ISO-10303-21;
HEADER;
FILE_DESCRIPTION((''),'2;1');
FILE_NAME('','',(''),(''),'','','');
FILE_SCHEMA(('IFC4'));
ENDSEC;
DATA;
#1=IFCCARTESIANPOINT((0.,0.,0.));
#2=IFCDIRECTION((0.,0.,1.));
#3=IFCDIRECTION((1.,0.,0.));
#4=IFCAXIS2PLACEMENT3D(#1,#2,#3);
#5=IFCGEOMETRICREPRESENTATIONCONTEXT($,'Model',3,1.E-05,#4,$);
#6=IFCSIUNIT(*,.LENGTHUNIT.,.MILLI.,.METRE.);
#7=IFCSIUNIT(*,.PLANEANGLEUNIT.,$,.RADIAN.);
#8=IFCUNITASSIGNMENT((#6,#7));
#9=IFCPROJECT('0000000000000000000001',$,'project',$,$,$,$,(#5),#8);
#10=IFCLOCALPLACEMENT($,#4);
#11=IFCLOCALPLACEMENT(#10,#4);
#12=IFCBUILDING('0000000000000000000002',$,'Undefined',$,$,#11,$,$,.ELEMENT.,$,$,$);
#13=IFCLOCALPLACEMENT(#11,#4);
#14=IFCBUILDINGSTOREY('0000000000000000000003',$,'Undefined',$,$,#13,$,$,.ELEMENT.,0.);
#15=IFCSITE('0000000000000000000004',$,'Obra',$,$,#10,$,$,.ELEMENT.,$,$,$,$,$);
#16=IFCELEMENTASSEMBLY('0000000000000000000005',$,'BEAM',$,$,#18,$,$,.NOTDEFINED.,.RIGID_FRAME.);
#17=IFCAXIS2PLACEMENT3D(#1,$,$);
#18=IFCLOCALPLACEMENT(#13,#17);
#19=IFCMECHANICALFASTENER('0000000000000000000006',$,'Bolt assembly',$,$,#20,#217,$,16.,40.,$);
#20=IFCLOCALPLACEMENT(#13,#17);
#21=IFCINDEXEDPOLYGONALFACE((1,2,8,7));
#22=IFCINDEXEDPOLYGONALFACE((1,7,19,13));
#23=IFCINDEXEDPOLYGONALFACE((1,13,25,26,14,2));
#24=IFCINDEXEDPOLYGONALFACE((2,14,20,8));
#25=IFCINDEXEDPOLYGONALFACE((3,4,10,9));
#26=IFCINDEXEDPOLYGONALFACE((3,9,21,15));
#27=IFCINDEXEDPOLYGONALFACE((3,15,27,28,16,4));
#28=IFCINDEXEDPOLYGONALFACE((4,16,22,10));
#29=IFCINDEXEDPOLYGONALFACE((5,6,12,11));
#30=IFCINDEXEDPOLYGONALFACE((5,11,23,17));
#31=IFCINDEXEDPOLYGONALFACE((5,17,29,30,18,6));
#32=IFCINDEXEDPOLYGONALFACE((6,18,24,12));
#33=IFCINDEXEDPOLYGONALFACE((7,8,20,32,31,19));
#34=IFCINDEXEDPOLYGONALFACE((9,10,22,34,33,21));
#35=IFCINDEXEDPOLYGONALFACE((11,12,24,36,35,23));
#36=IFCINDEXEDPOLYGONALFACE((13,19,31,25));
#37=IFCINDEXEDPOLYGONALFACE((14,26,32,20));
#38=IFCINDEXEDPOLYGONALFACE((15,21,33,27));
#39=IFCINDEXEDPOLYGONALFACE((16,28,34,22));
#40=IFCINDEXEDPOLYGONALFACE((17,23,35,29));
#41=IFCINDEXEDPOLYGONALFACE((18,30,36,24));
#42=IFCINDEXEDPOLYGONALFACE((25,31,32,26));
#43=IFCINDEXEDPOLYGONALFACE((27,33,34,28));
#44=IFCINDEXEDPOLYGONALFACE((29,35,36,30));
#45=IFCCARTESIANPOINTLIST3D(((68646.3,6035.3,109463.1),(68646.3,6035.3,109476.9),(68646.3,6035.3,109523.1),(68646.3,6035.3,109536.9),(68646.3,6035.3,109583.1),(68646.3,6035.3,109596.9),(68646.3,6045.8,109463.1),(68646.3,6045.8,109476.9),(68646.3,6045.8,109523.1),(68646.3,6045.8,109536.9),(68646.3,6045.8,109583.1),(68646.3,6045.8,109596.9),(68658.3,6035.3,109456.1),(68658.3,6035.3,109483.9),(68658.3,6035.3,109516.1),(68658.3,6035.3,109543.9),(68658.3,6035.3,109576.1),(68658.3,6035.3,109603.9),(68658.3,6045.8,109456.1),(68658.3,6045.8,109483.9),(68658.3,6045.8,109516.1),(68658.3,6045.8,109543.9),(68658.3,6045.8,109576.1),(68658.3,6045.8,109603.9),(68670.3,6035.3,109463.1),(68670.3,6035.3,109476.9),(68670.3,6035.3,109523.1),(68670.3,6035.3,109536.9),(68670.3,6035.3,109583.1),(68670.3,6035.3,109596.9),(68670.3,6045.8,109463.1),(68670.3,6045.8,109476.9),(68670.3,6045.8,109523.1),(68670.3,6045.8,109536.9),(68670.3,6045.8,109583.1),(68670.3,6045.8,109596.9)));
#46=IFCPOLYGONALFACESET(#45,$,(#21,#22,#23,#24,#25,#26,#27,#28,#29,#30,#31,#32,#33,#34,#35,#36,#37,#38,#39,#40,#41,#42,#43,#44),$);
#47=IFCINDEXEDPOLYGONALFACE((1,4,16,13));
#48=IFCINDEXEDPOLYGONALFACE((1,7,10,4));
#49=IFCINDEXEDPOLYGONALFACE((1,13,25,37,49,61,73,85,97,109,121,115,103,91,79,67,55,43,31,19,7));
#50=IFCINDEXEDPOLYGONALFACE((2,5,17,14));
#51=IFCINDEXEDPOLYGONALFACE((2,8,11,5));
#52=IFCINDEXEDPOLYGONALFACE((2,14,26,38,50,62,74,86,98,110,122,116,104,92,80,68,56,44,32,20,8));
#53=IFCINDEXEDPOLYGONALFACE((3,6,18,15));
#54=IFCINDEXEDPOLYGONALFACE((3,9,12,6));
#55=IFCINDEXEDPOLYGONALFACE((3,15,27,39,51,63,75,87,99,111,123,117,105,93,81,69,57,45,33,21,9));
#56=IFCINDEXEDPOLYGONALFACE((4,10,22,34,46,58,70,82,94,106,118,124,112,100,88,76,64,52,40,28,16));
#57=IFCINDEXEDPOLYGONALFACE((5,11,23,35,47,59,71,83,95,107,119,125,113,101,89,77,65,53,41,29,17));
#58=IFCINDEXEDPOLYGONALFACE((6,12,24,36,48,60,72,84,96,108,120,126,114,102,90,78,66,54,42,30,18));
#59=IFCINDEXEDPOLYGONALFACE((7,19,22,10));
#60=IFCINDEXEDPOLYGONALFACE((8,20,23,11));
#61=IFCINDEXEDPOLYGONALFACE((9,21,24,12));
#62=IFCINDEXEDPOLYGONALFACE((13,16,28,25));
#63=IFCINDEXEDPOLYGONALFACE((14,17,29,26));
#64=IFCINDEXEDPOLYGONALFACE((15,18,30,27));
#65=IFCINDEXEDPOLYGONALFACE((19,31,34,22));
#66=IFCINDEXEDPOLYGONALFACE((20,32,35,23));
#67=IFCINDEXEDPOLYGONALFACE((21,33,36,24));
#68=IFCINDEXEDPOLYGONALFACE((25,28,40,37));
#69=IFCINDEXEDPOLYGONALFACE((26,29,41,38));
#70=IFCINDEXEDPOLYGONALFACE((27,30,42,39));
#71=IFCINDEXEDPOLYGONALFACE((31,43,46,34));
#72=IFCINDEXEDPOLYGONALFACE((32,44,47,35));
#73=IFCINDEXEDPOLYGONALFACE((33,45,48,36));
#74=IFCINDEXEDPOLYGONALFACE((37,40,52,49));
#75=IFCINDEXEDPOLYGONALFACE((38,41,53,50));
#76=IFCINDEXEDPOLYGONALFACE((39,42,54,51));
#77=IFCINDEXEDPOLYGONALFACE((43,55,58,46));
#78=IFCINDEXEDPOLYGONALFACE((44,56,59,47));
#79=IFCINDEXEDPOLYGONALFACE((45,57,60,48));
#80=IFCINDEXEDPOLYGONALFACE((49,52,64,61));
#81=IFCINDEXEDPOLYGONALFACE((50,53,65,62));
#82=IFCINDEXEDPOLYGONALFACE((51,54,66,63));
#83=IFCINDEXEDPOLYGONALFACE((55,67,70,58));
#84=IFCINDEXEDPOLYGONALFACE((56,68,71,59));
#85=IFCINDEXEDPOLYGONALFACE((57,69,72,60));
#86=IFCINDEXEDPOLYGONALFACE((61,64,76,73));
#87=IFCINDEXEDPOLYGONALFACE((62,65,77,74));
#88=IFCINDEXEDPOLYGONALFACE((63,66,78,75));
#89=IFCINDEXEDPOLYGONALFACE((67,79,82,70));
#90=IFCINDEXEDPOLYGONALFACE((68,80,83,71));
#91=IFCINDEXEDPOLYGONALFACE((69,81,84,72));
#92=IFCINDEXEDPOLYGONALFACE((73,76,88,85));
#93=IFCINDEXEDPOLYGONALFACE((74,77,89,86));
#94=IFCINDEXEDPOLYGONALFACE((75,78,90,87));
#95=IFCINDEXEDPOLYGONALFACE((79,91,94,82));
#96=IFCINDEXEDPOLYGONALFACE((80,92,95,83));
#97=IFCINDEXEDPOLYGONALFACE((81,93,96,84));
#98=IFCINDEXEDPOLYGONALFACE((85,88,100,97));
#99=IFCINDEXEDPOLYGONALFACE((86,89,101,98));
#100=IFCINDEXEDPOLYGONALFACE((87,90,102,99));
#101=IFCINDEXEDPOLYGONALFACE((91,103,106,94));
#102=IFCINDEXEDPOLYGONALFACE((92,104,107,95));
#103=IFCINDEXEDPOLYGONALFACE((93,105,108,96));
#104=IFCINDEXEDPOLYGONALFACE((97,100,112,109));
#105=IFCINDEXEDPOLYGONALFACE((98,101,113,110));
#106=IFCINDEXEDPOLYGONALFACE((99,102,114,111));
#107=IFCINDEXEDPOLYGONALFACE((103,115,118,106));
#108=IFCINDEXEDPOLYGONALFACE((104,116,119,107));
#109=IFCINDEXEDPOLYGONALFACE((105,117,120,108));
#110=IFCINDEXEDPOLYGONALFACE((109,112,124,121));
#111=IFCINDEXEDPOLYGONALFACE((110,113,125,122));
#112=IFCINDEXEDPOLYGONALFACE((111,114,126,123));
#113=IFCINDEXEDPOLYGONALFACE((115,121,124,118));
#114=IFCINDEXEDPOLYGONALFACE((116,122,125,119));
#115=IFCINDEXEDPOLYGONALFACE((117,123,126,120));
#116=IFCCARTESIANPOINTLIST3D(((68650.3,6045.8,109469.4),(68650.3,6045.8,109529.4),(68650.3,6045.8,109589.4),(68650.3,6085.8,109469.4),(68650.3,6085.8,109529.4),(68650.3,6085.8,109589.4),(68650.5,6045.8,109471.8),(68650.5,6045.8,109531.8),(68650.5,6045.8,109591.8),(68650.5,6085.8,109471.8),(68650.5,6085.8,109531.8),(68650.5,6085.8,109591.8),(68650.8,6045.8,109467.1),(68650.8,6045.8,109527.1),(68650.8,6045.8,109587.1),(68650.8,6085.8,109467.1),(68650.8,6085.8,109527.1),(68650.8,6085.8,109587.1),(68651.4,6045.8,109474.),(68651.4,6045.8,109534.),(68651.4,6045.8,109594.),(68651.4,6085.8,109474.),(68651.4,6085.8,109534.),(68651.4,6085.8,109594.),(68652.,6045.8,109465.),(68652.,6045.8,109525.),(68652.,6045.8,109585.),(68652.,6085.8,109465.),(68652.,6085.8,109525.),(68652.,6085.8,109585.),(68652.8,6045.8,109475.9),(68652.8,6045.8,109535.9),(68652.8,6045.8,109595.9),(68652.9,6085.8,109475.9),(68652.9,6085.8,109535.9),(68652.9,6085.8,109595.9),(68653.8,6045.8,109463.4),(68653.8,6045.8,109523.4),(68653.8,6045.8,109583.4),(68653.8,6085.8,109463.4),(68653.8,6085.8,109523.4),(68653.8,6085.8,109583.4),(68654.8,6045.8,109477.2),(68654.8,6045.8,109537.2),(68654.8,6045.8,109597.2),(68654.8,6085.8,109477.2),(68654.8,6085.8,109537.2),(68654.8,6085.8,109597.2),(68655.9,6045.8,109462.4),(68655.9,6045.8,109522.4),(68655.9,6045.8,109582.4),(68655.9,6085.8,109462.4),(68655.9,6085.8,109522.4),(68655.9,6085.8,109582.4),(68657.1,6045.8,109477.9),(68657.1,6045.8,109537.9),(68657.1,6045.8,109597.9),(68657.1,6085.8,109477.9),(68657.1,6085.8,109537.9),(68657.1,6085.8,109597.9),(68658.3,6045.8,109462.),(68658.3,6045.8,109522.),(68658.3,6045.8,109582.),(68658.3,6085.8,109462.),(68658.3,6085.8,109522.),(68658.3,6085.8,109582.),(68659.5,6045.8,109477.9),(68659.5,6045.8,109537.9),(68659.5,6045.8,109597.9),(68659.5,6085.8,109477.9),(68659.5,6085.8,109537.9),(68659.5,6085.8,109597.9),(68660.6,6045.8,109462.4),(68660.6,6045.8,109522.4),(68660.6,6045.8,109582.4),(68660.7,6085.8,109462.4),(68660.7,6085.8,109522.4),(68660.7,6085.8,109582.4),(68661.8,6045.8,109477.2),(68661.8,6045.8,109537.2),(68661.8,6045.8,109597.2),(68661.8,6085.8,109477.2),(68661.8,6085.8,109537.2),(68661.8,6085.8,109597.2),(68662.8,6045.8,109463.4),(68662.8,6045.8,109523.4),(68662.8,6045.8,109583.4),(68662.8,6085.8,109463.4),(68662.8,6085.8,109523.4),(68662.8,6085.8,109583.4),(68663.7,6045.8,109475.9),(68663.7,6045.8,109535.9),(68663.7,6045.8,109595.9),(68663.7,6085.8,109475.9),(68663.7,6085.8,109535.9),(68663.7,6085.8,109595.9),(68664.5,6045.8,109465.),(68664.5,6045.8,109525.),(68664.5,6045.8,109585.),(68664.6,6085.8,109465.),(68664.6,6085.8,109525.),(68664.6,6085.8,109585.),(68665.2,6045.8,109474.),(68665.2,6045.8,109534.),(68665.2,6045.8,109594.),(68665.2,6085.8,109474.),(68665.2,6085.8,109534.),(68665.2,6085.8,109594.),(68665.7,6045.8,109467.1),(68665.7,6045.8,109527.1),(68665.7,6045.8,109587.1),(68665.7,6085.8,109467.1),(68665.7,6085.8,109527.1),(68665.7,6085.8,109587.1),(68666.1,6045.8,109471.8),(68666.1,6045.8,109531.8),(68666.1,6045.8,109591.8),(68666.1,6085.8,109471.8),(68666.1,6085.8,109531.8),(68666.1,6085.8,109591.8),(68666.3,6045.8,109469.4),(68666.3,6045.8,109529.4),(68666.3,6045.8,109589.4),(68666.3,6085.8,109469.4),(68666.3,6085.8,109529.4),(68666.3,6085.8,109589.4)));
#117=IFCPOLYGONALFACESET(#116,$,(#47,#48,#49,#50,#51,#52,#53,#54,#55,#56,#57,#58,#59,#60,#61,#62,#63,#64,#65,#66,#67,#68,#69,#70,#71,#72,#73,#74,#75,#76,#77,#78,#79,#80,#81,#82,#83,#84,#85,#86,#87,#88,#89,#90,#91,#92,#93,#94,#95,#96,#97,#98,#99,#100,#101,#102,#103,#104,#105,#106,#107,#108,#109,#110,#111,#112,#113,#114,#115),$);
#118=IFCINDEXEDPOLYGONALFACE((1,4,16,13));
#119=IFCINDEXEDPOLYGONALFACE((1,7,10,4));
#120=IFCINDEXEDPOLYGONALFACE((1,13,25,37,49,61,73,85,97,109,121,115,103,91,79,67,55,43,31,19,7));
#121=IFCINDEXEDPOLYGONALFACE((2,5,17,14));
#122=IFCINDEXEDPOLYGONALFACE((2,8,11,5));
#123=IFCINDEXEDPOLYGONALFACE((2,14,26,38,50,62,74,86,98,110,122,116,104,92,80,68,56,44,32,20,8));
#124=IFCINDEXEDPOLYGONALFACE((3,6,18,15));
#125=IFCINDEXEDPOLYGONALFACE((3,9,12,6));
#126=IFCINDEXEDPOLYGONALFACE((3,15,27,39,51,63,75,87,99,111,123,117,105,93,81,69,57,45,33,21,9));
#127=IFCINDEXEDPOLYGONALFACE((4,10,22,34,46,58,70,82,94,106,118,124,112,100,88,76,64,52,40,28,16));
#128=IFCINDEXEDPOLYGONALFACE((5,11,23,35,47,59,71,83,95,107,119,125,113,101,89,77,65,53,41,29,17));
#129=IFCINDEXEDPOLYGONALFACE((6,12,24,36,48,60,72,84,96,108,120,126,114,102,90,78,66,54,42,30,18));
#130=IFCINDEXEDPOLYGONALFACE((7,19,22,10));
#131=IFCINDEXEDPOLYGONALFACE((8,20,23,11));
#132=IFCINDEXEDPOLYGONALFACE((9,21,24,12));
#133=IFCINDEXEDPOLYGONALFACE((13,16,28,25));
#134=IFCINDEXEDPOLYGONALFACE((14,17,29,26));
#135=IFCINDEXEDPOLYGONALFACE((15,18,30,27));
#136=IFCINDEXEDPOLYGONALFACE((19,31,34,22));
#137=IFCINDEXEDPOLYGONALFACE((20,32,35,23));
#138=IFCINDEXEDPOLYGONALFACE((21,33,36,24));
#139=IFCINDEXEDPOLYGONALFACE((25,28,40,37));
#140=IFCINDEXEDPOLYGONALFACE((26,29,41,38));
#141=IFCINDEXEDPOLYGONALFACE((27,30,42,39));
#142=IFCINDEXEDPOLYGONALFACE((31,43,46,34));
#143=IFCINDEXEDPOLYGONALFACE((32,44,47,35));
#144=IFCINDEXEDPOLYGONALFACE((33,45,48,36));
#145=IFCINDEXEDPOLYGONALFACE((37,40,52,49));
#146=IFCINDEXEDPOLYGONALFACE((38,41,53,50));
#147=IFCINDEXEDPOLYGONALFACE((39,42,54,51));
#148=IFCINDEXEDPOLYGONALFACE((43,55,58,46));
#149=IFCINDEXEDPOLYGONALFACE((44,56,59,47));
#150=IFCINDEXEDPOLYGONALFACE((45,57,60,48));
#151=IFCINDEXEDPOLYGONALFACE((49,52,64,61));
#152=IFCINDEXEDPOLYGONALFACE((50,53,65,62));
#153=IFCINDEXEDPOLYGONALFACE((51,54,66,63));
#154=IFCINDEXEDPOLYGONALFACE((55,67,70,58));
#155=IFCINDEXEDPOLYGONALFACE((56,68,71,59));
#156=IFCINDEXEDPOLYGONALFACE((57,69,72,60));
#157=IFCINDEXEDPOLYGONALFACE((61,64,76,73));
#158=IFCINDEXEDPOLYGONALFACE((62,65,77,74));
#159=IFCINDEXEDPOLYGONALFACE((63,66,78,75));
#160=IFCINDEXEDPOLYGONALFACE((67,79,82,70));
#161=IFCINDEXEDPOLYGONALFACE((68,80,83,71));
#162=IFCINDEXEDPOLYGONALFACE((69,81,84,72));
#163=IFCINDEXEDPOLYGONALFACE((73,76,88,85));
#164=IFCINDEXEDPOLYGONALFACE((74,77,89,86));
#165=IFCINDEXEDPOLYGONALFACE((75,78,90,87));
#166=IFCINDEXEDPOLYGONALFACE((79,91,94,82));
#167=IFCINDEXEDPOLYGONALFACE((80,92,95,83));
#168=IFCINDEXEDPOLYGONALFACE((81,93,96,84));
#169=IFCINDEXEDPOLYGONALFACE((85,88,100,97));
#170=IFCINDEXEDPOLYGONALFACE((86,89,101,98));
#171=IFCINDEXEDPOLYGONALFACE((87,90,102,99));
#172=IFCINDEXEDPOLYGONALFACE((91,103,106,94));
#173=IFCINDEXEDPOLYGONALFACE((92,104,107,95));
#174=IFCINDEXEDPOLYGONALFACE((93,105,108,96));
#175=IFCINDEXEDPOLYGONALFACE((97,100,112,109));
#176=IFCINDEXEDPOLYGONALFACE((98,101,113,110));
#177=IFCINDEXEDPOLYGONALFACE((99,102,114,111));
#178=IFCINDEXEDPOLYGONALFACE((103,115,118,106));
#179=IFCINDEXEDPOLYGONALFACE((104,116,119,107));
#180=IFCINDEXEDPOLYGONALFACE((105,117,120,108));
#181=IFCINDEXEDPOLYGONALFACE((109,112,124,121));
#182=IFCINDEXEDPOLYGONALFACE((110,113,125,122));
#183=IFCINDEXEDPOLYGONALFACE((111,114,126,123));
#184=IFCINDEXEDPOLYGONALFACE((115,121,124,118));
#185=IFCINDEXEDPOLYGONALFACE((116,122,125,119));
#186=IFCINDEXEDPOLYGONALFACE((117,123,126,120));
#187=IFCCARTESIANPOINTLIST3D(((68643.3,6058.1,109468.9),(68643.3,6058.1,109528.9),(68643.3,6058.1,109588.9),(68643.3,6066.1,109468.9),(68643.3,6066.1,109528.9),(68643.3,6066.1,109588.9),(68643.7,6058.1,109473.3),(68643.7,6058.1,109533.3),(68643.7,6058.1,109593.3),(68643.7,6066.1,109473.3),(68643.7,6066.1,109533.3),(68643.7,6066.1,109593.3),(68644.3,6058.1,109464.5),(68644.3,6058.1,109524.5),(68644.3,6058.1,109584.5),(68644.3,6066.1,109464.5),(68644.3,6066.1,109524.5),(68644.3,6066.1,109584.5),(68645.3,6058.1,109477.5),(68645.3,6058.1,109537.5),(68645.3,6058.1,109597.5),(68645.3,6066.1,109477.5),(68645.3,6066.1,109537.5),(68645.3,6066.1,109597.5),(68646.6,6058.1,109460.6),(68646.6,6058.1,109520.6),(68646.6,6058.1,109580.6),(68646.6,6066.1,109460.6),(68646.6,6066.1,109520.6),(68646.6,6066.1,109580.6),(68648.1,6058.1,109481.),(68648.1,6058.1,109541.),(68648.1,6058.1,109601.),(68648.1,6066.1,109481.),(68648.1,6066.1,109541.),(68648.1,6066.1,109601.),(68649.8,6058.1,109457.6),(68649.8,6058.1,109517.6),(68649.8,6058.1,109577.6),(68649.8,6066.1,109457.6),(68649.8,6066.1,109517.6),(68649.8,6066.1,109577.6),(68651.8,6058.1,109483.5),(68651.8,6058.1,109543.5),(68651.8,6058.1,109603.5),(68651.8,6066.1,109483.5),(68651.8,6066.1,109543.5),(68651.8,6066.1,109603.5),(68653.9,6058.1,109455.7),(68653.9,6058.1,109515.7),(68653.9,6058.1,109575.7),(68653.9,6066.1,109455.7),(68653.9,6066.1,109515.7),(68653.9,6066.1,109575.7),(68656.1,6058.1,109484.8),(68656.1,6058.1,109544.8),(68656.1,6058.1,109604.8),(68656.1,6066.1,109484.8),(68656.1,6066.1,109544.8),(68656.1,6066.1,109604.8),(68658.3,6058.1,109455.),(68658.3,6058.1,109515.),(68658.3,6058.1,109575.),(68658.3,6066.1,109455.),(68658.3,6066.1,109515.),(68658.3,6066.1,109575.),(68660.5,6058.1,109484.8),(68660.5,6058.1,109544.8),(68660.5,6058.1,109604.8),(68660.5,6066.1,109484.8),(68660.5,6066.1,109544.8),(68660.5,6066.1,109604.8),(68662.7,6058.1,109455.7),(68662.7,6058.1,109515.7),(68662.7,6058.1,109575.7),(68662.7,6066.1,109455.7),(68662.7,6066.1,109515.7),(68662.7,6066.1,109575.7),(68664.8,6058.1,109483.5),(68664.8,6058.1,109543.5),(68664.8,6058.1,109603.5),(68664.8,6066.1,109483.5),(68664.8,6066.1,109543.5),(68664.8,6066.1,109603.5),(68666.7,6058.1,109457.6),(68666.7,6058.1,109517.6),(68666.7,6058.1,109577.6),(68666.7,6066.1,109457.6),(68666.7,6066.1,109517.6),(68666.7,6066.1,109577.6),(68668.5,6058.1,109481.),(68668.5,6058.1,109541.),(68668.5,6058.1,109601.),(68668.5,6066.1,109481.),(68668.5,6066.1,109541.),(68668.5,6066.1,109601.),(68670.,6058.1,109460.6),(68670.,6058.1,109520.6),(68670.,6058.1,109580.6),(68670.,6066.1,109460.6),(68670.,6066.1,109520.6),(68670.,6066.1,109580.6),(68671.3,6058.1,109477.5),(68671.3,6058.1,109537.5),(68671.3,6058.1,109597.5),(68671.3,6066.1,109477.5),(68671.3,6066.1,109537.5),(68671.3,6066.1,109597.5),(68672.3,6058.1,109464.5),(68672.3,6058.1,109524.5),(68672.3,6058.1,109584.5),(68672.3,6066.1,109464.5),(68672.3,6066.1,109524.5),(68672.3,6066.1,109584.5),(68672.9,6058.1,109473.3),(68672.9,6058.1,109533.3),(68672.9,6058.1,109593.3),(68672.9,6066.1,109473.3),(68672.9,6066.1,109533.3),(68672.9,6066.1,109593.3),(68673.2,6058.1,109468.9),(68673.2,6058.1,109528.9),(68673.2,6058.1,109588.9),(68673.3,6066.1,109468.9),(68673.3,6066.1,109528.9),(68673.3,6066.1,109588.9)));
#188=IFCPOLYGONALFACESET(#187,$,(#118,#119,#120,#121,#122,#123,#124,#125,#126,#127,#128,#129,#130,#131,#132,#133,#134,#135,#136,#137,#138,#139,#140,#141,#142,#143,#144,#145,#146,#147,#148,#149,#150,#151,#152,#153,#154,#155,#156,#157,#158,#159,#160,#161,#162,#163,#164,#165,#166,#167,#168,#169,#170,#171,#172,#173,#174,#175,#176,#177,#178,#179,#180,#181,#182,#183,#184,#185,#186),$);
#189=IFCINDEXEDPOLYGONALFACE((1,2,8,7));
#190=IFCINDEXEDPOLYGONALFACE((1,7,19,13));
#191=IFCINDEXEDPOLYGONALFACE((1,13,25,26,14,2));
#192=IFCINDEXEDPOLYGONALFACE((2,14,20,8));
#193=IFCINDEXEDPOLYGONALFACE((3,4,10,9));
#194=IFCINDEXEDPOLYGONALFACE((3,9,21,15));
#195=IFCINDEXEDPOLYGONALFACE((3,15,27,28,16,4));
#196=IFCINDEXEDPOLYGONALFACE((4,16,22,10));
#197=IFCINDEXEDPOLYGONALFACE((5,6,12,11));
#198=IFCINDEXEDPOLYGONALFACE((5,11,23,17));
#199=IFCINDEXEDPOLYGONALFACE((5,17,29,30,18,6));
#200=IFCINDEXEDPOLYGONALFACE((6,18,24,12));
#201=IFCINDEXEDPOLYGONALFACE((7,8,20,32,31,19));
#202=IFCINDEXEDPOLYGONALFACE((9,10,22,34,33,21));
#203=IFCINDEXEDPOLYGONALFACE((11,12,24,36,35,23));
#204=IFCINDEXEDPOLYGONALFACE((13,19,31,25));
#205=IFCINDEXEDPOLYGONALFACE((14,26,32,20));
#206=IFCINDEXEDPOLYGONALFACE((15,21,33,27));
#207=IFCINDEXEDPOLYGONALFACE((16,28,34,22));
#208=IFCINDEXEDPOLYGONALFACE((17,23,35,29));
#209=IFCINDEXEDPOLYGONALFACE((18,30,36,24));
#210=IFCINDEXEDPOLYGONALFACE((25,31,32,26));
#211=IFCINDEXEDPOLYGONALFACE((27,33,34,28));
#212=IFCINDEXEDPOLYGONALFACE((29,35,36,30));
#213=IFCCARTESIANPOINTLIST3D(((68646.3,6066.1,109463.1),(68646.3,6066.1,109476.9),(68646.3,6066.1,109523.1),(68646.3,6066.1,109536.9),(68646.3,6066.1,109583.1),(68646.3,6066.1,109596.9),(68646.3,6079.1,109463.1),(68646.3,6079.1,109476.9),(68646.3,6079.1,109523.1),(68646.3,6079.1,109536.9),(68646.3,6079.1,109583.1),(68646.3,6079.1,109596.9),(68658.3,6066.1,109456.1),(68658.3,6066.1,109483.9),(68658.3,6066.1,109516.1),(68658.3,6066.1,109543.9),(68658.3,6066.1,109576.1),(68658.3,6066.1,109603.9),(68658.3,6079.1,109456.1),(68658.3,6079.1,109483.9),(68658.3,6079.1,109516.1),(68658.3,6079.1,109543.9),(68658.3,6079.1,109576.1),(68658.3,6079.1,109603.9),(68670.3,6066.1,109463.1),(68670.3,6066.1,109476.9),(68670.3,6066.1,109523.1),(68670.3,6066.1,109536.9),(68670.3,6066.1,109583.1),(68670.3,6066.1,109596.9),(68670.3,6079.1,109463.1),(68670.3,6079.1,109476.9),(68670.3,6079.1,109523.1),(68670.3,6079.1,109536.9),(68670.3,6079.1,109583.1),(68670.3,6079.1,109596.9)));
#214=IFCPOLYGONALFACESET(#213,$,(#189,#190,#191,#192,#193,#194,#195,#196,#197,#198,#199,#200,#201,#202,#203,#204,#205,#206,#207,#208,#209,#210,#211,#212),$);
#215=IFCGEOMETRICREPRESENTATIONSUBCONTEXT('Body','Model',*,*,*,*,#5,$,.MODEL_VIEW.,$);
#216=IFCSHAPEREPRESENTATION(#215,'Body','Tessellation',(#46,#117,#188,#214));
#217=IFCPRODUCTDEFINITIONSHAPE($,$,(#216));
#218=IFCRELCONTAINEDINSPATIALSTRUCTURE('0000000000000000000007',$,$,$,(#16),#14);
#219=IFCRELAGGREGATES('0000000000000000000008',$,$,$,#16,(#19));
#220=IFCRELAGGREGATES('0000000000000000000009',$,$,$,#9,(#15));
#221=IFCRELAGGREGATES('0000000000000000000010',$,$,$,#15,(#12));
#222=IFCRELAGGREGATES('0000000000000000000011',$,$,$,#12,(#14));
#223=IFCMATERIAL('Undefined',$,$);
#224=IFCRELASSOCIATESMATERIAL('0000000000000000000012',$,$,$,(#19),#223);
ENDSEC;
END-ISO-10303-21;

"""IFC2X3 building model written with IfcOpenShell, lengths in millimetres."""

from ifc_helpers import new_model, si_unit, frame, origin_with_axes, origin_2d_with_axis, place, context, subcontext, project, spatial, polyline, circle, outline, extrude, source, transform, mapped, material, element, aggregate, save


model = new_model("IFC2X3")

# Units and contexts
model_context = context("Model", 3, precision=1e-05, world=origin_with_axes())
body_context = subcontext(model_context, "Body", "Model", "MODEL_VIEW")
ifc_project = project(units=[si_unit("LENGTHUNIT", "METRE", prefix="MILLI"), si_unit("PLANEANGLEUNIT", "RADIAN")], contexts=[model_context])

# Site, building, storey
site_placement = place(None, origin_with_axes())
site = spatial("IfcSite", under=ifc_project, at=site_placement, Name="Obra", CompositionType="ELEMENT")
building_placement = place(site_placement, origin_with_axes())
building = spatial("IfcBuilding", under=site, at=building_placement, Name="Undefined", CompositionType="ELEMENT")
storey_placement = place(building_placement, origin_with_axes())
storey = spatial("IfcBuildingStorey", under=building, at=storey_placement, Name="Undefined", CompositionType="ELEMENT", Elevation=0.0)

# Element assembly
assembly_1_placement = place(storey_placement, origin_with_axes())
assembly_1 = element("IfcElementAssembly", 1, at=assembly_1_placement, inside=storey, Name="BEAM", AssemblyPlace="NOTDEFINED", PredefinedType="RIGID_FRAME")

# Shared definitions
ifc_material_1 = material(Name="Undefined")

# Shared definitions
shared_shape_1 = source(origin_with_axes(), body_context, "Body", "SweptSolid", [
    extrude(outline(polyline([(13.9, 0.0), (6.9, 12.0), (-6.9, 12.0), (-13.9, 0.0), (-6.9, -12.0), (6.9, -12.0), (13.9, 0.0)])), frame((0.0, -19.7, 0.0), z_axis=(0.0, 1.0, 0.0), x_axis=(1.0, 0.0, 0.0)), (0.0, 0.0, 1.0), 10.6),
    extrude(circle(Radius=8.0, at=origin_2d_with_axis()), frame((0.0, -9.1, 0.0), z_axis=(0.0, 1.0, 0.0), x_axis=(1.0, 0.0, 0.0)), (0.0, 0.0, 1.0), 40.0),
    extrude(circle(Radius=15.0, at=origin_2d_with_axis()), frame((0.0, 3.1, 0.0), z_axis=(0.0, 1.0, 0.0), x_axis=(1.0, 0.0, 0.0)), (0.0, 0.0, 1.0), 8.0),
    extrude(outline(polyline([(13.9, 0.0), (6.9, 12.0), (-6.9, 12.0), (-13.9, 0.0), (-6.9, -12.0), (6.9, -12.0), (13.9, 0.0)])), frame((0.0, 11.1, 0.0), z_axis=(0.0, 1.0, 0.0), x_axis=(1.0, 0.0, 0.0)), (0.0, 0.0, 1.0), 13.0),
])

# Mechanical fastener
mechanical_fastener_1_placement = place(assembly_1_placement, frame((68608.3, 6055.0, 109650.0), z_axis=(1.0, -0.000126, 0.0), x_axis=(0.0, 0.0, -1.0)))
mechanical_fastener_1 = element("IfcMechanicalFastener", 2, at=mechanical_fastener_1_placement, material=ifc_material_1, Name="Bolt assembly", NominalDiameter=16.0, NominalLength=40.0, context=body_context, shape_type="MappedRepresentation", body=[
    mapped(shared_shape_1, transform((60.0, 0.0, 50.0))),
    mapped(shared_shape_1, transform((120.0, 0.0, 50.0))),
    mapped(shared_shape_1, transform((180.0, 0.0, 50.0))),
])
aggregate(assembly_1, [mechanical_fastener_1])

save(model, "model.ifc")
